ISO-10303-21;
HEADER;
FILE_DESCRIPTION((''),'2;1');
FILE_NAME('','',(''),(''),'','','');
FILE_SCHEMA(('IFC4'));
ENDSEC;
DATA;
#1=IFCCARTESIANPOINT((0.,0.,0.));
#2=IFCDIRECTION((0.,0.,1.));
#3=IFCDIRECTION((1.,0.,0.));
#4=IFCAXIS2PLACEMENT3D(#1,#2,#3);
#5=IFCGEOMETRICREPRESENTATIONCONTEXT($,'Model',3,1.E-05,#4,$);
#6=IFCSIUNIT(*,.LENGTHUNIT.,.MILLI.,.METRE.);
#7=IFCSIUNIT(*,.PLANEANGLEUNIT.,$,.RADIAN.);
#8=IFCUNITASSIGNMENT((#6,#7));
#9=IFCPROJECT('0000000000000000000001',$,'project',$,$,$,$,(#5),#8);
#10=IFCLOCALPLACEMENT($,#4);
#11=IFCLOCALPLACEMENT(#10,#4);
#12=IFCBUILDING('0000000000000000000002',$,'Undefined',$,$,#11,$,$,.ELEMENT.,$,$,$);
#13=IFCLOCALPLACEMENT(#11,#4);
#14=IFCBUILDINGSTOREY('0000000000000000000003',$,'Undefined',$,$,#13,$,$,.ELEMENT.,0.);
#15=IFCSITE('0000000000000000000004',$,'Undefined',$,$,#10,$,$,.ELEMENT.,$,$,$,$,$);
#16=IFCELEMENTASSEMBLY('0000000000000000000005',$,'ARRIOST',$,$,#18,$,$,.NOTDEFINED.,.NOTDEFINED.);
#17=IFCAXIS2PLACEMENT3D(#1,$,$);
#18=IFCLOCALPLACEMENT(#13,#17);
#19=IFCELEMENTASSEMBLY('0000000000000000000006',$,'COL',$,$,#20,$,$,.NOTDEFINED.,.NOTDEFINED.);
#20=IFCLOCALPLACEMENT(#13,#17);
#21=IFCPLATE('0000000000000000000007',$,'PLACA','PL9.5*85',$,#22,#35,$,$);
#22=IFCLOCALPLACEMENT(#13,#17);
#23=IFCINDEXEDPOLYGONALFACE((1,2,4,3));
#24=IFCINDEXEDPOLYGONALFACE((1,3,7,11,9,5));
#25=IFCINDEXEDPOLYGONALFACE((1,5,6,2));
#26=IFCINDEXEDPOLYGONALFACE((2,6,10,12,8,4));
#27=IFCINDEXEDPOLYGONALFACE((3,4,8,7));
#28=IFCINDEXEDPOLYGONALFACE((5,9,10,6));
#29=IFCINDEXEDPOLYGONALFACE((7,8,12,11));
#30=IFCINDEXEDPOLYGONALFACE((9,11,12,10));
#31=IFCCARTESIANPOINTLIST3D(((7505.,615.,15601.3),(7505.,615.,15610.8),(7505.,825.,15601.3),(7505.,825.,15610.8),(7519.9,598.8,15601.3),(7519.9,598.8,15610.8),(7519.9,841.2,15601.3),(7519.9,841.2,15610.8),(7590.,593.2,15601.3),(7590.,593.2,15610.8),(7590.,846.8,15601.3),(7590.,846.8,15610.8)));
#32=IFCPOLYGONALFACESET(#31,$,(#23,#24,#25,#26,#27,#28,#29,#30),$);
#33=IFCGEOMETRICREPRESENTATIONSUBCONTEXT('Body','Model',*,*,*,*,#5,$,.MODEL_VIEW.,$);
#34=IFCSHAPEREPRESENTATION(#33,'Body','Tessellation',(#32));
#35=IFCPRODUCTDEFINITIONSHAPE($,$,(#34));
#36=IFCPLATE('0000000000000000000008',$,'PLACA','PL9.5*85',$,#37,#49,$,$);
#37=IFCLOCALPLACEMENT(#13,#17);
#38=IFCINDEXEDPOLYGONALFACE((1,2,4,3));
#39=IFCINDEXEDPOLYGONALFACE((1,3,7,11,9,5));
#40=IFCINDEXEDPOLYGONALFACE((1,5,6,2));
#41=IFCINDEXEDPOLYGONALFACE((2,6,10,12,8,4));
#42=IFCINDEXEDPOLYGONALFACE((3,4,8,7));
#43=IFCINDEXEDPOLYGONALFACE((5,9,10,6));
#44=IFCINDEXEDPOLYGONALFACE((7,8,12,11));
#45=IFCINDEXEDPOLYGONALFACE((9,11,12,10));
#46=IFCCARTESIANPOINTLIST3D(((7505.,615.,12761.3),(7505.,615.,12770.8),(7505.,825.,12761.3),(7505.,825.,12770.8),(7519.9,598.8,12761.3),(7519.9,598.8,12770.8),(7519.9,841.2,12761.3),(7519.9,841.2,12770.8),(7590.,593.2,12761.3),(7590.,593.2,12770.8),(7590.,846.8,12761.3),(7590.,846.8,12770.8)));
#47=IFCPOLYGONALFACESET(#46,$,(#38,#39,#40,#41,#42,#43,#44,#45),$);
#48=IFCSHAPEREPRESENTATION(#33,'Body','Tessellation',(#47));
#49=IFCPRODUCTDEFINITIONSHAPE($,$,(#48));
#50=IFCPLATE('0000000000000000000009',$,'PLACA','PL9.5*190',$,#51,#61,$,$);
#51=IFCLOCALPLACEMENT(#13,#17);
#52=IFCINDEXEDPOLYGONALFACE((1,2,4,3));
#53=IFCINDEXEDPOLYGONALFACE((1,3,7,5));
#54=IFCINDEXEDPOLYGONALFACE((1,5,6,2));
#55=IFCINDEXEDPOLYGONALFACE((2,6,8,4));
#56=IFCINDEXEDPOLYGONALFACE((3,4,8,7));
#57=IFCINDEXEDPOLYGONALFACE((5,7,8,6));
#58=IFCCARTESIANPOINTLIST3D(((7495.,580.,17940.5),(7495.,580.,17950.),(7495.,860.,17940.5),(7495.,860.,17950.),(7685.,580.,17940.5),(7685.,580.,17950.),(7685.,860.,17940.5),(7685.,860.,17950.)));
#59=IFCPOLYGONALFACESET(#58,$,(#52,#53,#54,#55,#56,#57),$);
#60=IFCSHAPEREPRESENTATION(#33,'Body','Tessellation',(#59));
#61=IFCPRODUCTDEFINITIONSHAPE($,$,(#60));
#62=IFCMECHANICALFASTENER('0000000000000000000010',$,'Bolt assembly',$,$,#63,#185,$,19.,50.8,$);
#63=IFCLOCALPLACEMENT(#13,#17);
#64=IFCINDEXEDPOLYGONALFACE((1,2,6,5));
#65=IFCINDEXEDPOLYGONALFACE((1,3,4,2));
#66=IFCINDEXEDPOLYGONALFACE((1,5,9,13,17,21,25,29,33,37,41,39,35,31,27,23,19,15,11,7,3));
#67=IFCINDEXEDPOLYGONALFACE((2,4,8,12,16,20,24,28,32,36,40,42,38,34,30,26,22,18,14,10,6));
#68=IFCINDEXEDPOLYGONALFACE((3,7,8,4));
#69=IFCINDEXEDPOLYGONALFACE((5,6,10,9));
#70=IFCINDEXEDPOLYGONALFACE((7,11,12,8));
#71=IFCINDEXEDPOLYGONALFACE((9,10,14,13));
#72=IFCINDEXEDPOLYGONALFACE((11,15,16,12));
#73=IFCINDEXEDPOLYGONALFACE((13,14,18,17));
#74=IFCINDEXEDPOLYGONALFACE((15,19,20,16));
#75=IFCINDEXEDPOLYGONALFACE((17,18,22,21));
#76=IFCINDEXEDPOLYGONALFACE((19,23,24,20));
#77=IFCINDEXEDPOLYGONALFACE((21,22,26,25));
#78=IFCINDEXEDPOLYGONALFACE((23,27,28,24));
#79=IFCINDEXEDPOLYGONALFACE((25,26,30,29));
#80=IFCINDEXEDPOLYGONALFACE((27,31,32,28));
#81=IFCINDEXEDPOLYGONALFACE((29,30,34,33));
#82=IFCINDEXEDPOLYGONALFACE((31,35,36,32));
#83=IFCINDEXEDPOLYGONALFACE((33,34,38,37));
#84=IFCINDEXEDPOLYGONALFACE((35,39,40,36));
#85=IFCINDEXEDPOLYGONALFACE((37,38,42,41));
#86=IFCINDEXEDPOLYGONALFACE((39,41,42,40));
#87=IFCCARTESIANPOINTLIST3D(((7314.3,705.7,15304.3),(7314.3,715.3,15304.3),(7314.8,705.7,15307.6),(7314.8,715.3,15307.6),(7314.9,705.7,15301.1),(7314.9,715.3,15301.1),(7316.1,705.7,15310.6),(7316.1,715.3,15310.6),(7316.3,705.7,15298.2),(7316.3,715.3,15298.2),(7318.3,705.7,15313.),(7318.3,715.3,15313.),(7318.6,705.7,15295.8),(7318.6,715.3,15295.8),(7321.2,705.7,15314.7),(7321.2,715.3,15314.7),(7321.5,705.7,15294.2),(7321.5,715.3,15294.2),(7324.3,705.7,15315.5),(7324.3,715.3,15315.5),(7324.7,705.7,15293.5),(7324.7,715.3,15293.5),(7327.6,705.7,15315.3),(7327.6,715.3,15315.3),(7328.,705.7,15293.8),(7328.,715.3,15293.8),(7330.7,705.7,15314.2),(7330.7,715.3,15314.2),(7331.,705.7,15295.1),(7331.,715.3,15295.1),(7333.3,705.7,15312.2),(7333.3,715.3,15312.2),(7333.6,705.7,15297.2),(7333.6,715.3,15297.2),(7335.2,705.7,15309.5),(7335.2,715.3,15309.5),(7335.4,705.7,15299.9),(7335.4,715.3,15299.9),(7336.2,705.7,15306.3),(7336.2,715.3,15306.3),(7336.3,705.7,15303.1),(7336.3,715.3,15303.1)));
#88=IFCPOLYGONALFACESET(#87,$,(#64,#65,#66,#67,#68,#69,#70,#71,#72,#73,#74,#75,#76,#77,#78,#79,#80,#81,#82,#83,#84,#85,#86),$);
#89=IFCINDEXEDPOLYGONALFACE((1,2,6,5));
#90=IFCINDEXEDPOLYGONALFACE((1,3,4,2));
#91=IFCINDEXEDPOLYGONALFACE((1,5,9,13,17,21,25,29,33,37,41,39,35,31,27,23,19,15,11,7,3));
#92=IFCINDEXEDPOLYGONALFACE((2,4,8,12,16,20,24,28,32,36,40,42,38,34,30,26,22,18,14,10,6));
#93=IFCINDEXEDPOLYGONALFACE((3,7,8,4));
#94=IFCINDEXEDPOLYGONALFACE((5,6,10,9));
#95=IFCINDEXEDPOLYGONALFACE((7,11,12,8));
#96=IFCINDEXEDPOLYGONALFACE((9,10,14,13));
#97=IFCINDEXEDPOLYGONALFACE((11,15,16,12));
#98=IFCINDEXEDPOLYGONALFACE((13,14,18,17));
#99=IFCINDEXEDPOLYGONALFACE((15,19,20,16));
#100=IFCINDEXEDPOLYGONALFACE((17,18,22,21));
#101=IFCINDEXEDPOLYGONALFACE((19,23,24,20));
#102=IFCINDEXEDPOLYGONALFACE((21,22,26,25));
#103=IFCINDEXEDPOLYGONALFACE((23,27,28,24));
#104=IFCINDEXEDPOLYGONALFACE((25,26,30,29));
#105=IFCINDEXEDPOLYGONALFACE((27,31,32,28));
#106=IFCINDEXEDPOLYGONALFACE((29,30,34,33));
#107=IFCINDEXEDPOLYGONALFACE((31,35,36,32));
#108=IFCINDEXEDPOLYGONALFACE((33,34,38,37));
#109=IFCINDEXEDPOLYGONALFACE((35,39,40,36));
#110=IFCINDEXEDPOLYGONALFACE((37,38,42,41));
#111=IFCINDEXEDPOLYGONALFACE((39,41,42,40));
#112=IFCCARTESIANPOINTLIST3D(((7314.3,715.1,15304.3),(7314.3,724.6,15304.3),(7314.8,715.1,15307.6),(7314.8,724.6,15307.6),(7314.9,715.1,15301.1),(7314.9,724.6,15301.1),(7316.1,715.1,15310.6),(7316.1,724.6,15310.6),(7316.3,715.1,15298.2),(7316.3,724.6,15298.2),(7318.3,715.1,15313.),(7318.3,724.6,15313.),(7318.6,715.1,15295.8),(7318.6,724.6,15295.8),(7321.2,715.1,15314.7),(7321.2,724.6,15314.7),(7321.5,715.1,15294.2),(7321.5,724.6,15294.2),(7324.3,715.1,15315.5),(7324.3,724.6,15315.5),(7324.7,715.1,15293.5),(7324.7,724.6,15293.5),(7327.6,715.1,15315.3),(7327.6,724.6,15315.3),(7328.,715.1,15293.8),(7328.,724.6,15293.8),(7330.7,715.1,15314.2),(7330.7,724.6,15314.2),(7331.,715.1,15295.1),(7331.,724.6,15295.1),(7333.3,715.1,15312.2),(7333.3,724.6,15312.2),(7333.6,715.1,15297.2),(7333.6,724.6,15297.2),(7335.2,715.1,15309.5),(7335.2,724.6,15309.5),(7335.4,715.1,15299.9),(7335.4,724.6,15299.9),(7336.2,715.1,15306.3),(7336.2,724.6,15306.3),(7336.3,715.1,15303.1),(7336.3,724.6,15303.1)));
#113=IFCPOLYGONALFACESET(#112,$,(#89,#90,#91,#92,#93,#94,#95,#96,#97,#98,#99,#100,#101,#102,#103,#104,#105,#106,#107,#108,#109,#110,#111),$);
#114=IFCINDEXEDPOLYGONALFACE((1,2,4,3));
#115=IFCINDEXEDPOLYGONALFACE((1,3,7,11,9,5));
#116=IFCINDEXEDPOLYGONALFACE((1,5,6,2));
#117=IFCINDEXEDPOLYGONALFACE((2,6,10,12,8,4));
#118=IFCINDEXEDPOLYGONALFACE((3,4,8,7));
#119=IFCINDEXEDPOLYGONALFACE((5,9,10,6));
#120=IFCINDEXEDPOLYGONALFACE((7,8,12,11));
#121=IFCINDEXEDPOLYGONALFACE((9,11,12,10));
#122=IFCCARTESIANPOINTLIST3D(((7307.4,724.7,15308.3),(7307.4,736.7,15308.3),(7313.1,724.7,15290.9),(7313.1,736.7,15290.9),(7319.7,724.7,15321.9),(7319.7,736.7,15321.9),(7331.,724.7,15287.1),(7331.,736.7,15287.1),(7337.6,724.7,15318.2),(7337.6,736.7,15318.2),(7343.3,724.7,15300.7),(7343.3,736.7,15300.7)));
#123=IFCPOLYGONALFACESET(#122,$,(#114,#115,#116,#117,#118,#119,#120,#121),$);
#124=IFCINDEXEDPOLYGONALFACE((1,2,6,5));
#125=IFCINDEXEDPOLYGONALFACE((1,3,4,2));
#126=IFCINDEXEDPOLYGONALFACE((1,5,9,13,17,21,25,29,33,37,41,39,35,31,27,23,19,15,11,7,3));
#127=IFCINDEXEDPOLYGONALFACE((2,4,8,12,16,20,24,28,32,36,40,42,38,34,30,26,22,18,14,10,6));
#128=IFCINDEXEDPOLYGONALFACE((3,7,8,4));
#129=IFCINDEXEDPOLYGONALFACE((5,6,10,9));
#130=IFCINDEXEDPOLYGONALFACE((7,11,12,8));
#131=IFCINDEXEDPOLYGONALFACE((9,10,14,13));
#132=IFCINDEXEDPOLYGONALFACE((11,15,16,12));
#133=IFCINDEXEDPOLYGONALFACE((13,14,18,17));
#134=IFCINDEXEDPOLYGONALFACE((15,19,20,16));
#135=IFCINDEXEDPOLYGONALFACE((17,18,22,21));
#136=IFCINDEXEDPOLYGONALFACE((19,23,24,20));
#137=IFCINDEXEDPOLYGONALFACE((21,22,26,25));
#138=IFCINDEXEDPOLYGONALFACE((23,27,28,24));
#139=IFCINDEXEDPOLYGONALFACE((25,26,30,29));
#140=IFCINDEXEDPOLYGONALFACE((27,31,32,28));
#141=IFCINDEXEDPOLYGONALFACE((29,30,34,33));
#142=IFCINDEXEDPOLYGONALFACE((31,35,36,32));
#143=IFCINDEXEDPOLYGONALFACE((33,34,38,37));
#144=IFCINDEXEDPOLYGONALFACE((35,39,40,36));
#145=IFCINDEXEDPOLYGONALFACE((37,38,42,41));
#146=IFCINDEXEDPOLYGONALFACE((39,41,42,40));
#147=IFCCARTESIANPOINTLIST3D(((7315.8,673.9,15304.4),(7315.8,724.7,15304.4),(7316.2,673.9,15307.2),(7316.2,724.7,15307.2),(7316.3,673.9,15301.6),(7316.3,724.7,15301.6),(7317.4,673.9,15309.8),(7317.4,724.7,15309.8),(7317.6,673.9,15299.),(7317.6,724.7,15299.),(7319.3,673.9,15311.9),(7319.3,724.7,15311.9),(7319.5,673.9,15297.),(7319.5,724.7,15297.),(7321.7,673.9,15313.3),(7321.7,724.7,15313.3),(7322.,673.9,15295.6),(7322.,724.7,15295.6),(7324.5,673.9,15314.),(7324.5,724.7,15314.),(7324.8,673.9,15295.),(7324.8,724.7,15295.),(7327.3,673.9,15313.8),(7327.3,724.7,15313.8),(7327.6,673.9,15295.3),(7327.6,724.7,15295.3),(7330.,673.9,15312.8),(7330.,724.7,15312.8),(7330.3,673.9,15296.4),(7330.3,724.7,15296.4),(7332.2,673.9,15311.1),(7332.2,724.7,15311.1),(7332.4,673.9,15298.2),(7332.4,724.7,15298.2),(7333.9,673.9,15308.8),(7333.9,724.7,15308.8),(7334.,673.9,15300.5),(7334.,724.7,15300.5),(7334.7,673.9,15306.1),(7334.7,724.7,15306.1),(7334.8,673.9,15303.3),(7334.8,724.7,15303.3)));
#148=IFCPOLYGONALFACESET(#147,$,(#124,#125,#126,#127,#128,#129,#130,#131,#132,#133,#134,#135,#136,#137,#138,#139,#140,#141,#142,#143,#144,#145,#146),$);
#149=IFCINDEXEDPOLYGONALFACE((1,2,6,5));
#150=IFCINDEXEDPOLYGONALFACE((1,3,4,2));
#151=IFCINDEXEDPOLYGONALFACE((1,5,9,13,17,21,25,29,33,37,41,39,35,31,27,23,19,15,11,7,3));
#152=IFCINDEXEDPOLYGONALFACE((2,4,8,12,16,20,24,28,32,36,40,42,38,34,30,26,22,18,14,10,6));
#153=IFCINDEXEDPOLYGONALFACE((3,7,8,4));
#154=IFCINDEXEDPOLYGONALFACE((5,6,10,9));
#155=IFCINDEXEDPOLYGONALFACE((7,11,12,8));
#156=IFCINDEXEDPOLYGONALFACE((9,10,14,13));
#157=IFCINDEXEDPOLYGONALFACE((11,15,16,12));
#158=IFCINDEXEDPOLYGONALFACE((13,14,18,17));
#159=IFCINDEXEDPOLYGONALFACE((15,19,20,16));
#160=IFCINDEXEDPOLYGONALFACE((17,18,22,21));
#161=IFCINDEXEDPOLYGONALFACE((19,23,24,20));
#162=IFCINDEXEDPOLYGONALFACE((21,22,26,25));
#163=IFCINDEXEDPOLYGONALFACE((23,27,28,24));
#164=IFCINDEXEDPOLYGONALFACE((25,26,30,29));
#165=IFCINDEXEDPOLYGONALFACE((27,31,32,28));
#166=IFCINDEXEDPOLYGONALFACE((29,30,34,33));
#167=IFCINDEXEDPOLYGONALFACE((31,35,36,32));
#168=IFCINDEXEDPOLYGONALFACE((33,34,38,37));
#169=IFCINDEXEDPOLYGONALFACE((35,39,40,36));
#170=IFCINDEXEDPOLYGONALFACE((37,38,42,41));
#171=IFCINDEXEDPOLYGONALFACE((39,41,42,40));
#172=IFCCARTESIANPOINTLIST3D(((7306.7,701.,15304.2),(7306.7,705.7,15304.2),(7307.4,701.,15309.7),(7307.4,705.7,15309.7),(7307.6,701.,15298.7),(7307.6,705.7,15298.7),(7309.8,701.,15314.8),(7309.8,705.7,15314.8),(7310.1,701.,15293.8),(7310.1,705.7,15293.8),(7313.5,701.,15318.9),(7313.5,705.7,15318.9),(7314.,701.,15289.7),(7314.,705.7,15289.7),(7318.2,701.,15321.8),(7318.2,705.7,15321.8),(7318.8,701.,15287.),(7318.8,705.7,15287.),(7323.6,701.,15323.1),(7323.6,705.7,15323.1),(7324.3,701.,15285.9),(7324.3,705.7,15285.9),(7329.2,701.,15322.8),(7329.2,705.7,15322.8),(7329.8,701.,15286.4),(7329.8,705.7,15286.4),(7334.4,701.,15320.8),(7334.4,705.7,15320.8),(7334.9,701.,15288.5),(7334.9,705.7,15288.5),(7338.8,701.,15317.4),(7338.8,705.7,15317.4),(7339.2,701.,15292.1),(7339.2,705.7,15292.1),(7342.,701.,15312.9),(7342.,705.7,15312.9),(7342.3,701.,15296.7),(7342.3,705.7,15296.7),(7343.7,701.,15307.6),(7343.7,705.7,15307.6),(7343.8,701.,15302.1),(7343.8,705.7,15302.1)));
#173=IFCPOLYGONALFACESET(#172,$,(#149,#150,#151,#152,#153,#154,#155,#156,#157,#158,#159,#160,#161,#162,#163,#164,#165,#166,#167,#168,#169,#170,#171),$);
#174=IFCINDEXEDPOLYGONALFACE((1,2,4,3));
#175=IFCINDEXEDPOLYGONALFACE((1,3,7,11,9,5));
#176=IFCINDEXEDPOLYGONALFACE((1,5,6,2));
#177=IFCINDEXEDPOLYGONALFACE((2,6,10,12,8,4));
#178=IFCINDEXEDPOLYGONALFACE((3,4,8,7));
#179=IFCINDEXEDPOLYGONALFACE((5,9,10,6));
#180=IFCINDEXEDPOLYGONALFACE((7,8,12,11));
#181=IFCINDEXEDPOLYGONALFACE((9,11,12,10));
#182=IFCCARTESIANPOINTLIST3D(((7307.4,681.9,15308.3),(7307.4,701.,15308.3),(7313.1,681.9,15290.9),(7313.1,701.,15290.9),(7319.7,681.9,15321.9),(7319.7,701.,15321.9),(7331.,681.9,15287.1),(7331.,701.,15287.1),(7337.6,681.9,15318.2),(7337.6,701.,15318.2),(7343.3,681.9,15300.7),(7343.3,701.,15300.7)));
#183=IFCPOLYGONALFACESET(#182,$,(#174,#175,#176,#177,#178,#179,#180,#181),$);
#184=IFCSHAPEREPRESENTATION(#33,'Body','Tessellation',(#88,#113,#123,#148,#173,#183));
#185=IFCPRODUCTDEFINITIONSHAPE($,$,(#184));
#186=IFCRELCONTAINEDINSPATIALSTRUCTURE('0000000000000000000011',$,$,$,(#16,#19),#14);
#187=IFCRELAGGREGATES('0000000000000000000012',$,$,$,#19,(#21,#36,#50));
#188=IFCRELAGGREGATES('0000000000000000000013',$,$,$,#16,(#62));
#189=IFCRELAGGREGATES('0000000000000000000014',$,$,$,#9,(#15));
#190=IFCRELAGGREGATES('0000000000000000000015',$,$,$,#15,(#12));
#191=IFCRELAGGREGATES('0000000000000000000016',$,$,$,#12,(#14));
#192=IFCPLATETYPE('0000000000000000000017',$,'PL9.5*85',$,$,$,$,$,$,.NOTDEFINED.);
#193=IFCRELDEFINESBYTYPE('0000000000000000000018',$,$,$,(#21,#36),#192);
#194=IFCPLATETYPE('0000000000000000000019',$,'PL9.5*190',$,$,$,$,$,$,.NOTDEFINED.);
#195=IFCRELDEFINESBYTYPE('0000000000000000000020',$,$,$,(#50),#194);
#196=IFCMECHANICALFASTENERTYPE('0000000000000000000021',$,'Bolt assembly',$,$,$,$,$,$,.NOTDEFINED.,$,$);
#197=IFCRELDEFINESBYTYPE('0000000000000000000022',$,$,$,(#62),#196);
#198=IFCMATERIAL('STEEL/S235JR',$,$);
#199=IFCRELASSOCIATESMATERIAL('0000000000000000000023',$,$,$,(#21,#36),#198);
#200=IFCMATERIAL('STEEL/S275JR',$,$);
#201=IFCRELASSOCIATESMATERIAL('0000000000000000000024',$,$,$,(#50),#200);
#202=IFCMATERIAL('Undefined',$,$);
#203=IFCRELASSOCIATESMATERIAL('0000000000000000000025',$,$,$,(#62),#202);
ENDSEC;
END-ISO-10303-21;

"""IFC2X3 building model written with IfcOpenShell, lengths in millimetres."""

from ifc_helpers import new_model, si_unit, frame, origin_with_axes, origin_2d_with_axis, place, context, subcontext, project, spatial, polyline, circle, outline, extrude, source, transform, mapped, material, type_object, element, aggregate, save


model = new_model("IFC2X3")

# Units and contexts
model_context = context("Model", 3, precision=1e-05, world=origin_with_axes())
body_context = subcontext(model_context, "Body", "Model", "MODEL_VIEW")
ifc_project = project(units=[si_unit("LENGTHUNIT", "METRE", prefix="MILLI"), si_unit("PLANEANGLEUNIT", "RADIAN")], contexts=[model_context])

# Site, building, storey
site_placement = place(None, origin_with_axes())
site = spatial("IfcSite", under=ifc_project, at=site_placement, Name="Undefined", CompositionType="ELEMENT")
building_placement = place(site_placement, origin_with_axes())
building = spatial("IfcBuilding", under=site, at=building_placement, Name="Undefined", CompositionType="ELEMENT")
storey_placement = place(building_placement, origin_with_axes())
storey = spatial("IfcBuildingStorey", under=building, at=storey_placement, Name="Undefined", CompositionType="ELEMENT", Elevation=0.0)

# Shared definitions
ifc_material_1 = material(Name="STEEL/S275JR")

# Shared definitions
ifc_material_2 = material(Name="STEEL/S235JR")

# Element assemblies
assembly_1_placement = place(storey_placement, origin_with_axes())
assembly_1 = element("IfcElementAssembly", 1, at=assembly_1_placement, inside=storey, Name="ARRIOST", AssemblyPlace="NOTDEFINED", PredefinedType="NOTDEFINED")
assembly_2_placement = place(storey_placement, origin_with_axes())
assembly_2 = element("IfcElementAssembly", 2, at=assembly_2_placement, inside=storey, Name="COL", AssemblyPlace="NOTDEFINED", PredefinedType="NOTDEFINED")

# Plates
plate_type_1 = type_object("IfcPlateType", Name="PL9.5*85", PredefinedType="NOTDEFINED")
plate_1_placement = place(assembly_2_placement, frame((7590.0, 846.8, 15606.0), z_axis=(0.0, 0.0, 1.0), x_axis=(-0.996815, -0.079745, 0.0)))
plate_1 = element("IfcPlate", 3, at=plate_1_placement, type_object=plate_type_1, material=ifc_material_2, Name="PLACA", Description="PL9.5*85", context=body_context, shape_type="SweptSolid", body=[
    extrude(outline(polyline([(0.0, 0.0), (70.3, 0.0), (86.5, 15.0), (103.2, 224.3), (89.6, 241.6), (20.2, 252.8), (0.0, 0.0)])), frame((0.0, 0.0, -4.7), z_axis=(0.0, 0.0, 1.0), x_axis=(1.0, 0.0, 0.0)), (0.0, 0.0, 1.0), 9.5),
])
plate_2_placement = place(assembly_2_placement, frame((7590.0, 846.8, 12766.0), z_axis=(0.0, 0.0, 1.0), x_axis=(-0.996815, -0.079745, 0.0)))
plate_2 = element("IfcPlate", 4, at=plate_2_placement, type_object=plate_type_1, material=ifc_material_2, Name="PLACA", Description="PL9.5*85", context=body_context, shape_type="SweptSolid", body=[
    extrude(outline(polyline([(0.0, 0.0), (70.3, 0.0), (86.5, 15.0), (103.2, 224.3), (89.6, 241.6), (20.2, 252.8), (0.0, 0.0)])), frame((0.0, 0.0, -4.7), z_axis=(0.0, 0.0, 1.0), x_axis=(1.0, 0.0, 0.0)), (0.0, 0.0, 1.0), 9.5),
])
plate_type_2 = type_object("IfcPlateType", Name="PL9.5*190", PredefinedType="NOTDEFINED")
plate_3_placement = place(assembly_2_placement, frame((7495.0, 860.0, 17945.2), z_axis=(0.0, 0.0, 1.0), x_axis=(0.0, -1.0, 0.0)))
plate_3 = element("IfcPlate", 5, at=plate_3_placement, type_object=plate_type_2, material=ifc_material_1, Name="PLACA", Description="PL9.5*190", context=body_context, shape_type="SweptSolid", body=[
    extrude(outline(polyline([(0.0, 0.0), (280.0, 0.0), (280.0, 190.0), (0.0, 190.0), (0.0, 0.0)])), frame((0.0, 0.0, -4.7), z_axis=(0.0, 0.0, 1.0), x_axis=(1.0, 0.0, 0.0)), (0.0, 0.0, 1.0), 9.5),
])
aggregate(assembly_2, [plate_1, plate_2, plate_3])

# Shared definitions
ifc_material_3 = material(Name="Undefined")
mechanical_fastener_type = type_object("IfcMechanicalFastenerType", Name="Bolt assembly")

# Mechanical fastener
shared_shape_1 = source(origin_with_axes(), body_context, "Body", "SweptSolid", [
    extrude(circle(Radius=11.0, at=origin_2d_with_axis()), frame((0.0, 4.6, 0.0), z_axis=(0.0, 1.0, 0.0), x_axis=(1.0, 0.0, 0.0)), (0.0, 0.0, 1.0), 9.6),
    extrude(circle(Radius=11.0, at=origin_2d_with_axis()), frame((0.0, -4.6, 0.0), z_axis=(0.0, 1.0, 0.0), x_axis=(1.0, 0.0, 0.0)), (0.0, 0.0, 1.0), 9.5),
    extrude(outline(polyline([(15.9, -9.2), (15.9, 9.2), (0.0, 18.3), (-15.9, 9.2), (-15.9, -9.2), (0.0, -18.3), (15.9, -9.2)])), frame((0.0, -16.7, 0.0), z_axis=(0.0, 1.0, 0.0), x_axis=(1.0, 0.0, 0.0)), (0.0, 0.0, 1.0), 11.9),
    extrude(circle(Radius=9.5, at=origin_2d_with_axis()), frame((0.0, -4.7, 0.0), z_axis=(0.0, 1.0, 0.0), x_axis=(1.0, 0.0, 0.0)), (0.0, 0.0, 1.0), 50.8),
    extrude(circle(Radius=18.7, at=origin_2d_with_axis()), frame((0.0, 14.2, 0.0), z_axis=(0.0, 1.0, 0.0), x_axis=(1.0, 0.0, 0.0)), (0.0, 0.0, 1.0), 4.8),
    extrude(outline(polyline([(15.9, -9.2), (15.9, 9.2), (0.0, 18.3), (-15.9, 9.2), (-15.9, -9.2), (0.0, -18.3), (15.9, -9.2)])), frame((0.0, 19.0, 0.0), z_axis=(0.0, 1.0, 0.0), x_axis=(1.0, 0.0, 0.0)), (0.0, 0.0, 1.0), 19.1),
])
mechanical_fastener_1_placement = place(assembly_1_placement, frame((7325.4, 720.0, 15304.5), z_axis=(-0.310822, 0.0, 0.950468), x_axis=(-0.950468, 0.0, -0.310822)))
mechanical_fastener_1 = element("IfcMechanicalFastener", 6, at=mechanical_fastener_1_placement, type_object=mechanical_fastener_type, material=ifc_material_3, Name="Bolt assembly", NominalDiameter=19.0, NominalLength=50.8, context=body_context, shape_type="MappedRepresentation", body=[
    mapped(shared_shape_1, transform((0.0, 0.0, 0.0))),
])
aggregate(assembly_1, [mechanical_fastener_1])

save(model, "model.ifc")
